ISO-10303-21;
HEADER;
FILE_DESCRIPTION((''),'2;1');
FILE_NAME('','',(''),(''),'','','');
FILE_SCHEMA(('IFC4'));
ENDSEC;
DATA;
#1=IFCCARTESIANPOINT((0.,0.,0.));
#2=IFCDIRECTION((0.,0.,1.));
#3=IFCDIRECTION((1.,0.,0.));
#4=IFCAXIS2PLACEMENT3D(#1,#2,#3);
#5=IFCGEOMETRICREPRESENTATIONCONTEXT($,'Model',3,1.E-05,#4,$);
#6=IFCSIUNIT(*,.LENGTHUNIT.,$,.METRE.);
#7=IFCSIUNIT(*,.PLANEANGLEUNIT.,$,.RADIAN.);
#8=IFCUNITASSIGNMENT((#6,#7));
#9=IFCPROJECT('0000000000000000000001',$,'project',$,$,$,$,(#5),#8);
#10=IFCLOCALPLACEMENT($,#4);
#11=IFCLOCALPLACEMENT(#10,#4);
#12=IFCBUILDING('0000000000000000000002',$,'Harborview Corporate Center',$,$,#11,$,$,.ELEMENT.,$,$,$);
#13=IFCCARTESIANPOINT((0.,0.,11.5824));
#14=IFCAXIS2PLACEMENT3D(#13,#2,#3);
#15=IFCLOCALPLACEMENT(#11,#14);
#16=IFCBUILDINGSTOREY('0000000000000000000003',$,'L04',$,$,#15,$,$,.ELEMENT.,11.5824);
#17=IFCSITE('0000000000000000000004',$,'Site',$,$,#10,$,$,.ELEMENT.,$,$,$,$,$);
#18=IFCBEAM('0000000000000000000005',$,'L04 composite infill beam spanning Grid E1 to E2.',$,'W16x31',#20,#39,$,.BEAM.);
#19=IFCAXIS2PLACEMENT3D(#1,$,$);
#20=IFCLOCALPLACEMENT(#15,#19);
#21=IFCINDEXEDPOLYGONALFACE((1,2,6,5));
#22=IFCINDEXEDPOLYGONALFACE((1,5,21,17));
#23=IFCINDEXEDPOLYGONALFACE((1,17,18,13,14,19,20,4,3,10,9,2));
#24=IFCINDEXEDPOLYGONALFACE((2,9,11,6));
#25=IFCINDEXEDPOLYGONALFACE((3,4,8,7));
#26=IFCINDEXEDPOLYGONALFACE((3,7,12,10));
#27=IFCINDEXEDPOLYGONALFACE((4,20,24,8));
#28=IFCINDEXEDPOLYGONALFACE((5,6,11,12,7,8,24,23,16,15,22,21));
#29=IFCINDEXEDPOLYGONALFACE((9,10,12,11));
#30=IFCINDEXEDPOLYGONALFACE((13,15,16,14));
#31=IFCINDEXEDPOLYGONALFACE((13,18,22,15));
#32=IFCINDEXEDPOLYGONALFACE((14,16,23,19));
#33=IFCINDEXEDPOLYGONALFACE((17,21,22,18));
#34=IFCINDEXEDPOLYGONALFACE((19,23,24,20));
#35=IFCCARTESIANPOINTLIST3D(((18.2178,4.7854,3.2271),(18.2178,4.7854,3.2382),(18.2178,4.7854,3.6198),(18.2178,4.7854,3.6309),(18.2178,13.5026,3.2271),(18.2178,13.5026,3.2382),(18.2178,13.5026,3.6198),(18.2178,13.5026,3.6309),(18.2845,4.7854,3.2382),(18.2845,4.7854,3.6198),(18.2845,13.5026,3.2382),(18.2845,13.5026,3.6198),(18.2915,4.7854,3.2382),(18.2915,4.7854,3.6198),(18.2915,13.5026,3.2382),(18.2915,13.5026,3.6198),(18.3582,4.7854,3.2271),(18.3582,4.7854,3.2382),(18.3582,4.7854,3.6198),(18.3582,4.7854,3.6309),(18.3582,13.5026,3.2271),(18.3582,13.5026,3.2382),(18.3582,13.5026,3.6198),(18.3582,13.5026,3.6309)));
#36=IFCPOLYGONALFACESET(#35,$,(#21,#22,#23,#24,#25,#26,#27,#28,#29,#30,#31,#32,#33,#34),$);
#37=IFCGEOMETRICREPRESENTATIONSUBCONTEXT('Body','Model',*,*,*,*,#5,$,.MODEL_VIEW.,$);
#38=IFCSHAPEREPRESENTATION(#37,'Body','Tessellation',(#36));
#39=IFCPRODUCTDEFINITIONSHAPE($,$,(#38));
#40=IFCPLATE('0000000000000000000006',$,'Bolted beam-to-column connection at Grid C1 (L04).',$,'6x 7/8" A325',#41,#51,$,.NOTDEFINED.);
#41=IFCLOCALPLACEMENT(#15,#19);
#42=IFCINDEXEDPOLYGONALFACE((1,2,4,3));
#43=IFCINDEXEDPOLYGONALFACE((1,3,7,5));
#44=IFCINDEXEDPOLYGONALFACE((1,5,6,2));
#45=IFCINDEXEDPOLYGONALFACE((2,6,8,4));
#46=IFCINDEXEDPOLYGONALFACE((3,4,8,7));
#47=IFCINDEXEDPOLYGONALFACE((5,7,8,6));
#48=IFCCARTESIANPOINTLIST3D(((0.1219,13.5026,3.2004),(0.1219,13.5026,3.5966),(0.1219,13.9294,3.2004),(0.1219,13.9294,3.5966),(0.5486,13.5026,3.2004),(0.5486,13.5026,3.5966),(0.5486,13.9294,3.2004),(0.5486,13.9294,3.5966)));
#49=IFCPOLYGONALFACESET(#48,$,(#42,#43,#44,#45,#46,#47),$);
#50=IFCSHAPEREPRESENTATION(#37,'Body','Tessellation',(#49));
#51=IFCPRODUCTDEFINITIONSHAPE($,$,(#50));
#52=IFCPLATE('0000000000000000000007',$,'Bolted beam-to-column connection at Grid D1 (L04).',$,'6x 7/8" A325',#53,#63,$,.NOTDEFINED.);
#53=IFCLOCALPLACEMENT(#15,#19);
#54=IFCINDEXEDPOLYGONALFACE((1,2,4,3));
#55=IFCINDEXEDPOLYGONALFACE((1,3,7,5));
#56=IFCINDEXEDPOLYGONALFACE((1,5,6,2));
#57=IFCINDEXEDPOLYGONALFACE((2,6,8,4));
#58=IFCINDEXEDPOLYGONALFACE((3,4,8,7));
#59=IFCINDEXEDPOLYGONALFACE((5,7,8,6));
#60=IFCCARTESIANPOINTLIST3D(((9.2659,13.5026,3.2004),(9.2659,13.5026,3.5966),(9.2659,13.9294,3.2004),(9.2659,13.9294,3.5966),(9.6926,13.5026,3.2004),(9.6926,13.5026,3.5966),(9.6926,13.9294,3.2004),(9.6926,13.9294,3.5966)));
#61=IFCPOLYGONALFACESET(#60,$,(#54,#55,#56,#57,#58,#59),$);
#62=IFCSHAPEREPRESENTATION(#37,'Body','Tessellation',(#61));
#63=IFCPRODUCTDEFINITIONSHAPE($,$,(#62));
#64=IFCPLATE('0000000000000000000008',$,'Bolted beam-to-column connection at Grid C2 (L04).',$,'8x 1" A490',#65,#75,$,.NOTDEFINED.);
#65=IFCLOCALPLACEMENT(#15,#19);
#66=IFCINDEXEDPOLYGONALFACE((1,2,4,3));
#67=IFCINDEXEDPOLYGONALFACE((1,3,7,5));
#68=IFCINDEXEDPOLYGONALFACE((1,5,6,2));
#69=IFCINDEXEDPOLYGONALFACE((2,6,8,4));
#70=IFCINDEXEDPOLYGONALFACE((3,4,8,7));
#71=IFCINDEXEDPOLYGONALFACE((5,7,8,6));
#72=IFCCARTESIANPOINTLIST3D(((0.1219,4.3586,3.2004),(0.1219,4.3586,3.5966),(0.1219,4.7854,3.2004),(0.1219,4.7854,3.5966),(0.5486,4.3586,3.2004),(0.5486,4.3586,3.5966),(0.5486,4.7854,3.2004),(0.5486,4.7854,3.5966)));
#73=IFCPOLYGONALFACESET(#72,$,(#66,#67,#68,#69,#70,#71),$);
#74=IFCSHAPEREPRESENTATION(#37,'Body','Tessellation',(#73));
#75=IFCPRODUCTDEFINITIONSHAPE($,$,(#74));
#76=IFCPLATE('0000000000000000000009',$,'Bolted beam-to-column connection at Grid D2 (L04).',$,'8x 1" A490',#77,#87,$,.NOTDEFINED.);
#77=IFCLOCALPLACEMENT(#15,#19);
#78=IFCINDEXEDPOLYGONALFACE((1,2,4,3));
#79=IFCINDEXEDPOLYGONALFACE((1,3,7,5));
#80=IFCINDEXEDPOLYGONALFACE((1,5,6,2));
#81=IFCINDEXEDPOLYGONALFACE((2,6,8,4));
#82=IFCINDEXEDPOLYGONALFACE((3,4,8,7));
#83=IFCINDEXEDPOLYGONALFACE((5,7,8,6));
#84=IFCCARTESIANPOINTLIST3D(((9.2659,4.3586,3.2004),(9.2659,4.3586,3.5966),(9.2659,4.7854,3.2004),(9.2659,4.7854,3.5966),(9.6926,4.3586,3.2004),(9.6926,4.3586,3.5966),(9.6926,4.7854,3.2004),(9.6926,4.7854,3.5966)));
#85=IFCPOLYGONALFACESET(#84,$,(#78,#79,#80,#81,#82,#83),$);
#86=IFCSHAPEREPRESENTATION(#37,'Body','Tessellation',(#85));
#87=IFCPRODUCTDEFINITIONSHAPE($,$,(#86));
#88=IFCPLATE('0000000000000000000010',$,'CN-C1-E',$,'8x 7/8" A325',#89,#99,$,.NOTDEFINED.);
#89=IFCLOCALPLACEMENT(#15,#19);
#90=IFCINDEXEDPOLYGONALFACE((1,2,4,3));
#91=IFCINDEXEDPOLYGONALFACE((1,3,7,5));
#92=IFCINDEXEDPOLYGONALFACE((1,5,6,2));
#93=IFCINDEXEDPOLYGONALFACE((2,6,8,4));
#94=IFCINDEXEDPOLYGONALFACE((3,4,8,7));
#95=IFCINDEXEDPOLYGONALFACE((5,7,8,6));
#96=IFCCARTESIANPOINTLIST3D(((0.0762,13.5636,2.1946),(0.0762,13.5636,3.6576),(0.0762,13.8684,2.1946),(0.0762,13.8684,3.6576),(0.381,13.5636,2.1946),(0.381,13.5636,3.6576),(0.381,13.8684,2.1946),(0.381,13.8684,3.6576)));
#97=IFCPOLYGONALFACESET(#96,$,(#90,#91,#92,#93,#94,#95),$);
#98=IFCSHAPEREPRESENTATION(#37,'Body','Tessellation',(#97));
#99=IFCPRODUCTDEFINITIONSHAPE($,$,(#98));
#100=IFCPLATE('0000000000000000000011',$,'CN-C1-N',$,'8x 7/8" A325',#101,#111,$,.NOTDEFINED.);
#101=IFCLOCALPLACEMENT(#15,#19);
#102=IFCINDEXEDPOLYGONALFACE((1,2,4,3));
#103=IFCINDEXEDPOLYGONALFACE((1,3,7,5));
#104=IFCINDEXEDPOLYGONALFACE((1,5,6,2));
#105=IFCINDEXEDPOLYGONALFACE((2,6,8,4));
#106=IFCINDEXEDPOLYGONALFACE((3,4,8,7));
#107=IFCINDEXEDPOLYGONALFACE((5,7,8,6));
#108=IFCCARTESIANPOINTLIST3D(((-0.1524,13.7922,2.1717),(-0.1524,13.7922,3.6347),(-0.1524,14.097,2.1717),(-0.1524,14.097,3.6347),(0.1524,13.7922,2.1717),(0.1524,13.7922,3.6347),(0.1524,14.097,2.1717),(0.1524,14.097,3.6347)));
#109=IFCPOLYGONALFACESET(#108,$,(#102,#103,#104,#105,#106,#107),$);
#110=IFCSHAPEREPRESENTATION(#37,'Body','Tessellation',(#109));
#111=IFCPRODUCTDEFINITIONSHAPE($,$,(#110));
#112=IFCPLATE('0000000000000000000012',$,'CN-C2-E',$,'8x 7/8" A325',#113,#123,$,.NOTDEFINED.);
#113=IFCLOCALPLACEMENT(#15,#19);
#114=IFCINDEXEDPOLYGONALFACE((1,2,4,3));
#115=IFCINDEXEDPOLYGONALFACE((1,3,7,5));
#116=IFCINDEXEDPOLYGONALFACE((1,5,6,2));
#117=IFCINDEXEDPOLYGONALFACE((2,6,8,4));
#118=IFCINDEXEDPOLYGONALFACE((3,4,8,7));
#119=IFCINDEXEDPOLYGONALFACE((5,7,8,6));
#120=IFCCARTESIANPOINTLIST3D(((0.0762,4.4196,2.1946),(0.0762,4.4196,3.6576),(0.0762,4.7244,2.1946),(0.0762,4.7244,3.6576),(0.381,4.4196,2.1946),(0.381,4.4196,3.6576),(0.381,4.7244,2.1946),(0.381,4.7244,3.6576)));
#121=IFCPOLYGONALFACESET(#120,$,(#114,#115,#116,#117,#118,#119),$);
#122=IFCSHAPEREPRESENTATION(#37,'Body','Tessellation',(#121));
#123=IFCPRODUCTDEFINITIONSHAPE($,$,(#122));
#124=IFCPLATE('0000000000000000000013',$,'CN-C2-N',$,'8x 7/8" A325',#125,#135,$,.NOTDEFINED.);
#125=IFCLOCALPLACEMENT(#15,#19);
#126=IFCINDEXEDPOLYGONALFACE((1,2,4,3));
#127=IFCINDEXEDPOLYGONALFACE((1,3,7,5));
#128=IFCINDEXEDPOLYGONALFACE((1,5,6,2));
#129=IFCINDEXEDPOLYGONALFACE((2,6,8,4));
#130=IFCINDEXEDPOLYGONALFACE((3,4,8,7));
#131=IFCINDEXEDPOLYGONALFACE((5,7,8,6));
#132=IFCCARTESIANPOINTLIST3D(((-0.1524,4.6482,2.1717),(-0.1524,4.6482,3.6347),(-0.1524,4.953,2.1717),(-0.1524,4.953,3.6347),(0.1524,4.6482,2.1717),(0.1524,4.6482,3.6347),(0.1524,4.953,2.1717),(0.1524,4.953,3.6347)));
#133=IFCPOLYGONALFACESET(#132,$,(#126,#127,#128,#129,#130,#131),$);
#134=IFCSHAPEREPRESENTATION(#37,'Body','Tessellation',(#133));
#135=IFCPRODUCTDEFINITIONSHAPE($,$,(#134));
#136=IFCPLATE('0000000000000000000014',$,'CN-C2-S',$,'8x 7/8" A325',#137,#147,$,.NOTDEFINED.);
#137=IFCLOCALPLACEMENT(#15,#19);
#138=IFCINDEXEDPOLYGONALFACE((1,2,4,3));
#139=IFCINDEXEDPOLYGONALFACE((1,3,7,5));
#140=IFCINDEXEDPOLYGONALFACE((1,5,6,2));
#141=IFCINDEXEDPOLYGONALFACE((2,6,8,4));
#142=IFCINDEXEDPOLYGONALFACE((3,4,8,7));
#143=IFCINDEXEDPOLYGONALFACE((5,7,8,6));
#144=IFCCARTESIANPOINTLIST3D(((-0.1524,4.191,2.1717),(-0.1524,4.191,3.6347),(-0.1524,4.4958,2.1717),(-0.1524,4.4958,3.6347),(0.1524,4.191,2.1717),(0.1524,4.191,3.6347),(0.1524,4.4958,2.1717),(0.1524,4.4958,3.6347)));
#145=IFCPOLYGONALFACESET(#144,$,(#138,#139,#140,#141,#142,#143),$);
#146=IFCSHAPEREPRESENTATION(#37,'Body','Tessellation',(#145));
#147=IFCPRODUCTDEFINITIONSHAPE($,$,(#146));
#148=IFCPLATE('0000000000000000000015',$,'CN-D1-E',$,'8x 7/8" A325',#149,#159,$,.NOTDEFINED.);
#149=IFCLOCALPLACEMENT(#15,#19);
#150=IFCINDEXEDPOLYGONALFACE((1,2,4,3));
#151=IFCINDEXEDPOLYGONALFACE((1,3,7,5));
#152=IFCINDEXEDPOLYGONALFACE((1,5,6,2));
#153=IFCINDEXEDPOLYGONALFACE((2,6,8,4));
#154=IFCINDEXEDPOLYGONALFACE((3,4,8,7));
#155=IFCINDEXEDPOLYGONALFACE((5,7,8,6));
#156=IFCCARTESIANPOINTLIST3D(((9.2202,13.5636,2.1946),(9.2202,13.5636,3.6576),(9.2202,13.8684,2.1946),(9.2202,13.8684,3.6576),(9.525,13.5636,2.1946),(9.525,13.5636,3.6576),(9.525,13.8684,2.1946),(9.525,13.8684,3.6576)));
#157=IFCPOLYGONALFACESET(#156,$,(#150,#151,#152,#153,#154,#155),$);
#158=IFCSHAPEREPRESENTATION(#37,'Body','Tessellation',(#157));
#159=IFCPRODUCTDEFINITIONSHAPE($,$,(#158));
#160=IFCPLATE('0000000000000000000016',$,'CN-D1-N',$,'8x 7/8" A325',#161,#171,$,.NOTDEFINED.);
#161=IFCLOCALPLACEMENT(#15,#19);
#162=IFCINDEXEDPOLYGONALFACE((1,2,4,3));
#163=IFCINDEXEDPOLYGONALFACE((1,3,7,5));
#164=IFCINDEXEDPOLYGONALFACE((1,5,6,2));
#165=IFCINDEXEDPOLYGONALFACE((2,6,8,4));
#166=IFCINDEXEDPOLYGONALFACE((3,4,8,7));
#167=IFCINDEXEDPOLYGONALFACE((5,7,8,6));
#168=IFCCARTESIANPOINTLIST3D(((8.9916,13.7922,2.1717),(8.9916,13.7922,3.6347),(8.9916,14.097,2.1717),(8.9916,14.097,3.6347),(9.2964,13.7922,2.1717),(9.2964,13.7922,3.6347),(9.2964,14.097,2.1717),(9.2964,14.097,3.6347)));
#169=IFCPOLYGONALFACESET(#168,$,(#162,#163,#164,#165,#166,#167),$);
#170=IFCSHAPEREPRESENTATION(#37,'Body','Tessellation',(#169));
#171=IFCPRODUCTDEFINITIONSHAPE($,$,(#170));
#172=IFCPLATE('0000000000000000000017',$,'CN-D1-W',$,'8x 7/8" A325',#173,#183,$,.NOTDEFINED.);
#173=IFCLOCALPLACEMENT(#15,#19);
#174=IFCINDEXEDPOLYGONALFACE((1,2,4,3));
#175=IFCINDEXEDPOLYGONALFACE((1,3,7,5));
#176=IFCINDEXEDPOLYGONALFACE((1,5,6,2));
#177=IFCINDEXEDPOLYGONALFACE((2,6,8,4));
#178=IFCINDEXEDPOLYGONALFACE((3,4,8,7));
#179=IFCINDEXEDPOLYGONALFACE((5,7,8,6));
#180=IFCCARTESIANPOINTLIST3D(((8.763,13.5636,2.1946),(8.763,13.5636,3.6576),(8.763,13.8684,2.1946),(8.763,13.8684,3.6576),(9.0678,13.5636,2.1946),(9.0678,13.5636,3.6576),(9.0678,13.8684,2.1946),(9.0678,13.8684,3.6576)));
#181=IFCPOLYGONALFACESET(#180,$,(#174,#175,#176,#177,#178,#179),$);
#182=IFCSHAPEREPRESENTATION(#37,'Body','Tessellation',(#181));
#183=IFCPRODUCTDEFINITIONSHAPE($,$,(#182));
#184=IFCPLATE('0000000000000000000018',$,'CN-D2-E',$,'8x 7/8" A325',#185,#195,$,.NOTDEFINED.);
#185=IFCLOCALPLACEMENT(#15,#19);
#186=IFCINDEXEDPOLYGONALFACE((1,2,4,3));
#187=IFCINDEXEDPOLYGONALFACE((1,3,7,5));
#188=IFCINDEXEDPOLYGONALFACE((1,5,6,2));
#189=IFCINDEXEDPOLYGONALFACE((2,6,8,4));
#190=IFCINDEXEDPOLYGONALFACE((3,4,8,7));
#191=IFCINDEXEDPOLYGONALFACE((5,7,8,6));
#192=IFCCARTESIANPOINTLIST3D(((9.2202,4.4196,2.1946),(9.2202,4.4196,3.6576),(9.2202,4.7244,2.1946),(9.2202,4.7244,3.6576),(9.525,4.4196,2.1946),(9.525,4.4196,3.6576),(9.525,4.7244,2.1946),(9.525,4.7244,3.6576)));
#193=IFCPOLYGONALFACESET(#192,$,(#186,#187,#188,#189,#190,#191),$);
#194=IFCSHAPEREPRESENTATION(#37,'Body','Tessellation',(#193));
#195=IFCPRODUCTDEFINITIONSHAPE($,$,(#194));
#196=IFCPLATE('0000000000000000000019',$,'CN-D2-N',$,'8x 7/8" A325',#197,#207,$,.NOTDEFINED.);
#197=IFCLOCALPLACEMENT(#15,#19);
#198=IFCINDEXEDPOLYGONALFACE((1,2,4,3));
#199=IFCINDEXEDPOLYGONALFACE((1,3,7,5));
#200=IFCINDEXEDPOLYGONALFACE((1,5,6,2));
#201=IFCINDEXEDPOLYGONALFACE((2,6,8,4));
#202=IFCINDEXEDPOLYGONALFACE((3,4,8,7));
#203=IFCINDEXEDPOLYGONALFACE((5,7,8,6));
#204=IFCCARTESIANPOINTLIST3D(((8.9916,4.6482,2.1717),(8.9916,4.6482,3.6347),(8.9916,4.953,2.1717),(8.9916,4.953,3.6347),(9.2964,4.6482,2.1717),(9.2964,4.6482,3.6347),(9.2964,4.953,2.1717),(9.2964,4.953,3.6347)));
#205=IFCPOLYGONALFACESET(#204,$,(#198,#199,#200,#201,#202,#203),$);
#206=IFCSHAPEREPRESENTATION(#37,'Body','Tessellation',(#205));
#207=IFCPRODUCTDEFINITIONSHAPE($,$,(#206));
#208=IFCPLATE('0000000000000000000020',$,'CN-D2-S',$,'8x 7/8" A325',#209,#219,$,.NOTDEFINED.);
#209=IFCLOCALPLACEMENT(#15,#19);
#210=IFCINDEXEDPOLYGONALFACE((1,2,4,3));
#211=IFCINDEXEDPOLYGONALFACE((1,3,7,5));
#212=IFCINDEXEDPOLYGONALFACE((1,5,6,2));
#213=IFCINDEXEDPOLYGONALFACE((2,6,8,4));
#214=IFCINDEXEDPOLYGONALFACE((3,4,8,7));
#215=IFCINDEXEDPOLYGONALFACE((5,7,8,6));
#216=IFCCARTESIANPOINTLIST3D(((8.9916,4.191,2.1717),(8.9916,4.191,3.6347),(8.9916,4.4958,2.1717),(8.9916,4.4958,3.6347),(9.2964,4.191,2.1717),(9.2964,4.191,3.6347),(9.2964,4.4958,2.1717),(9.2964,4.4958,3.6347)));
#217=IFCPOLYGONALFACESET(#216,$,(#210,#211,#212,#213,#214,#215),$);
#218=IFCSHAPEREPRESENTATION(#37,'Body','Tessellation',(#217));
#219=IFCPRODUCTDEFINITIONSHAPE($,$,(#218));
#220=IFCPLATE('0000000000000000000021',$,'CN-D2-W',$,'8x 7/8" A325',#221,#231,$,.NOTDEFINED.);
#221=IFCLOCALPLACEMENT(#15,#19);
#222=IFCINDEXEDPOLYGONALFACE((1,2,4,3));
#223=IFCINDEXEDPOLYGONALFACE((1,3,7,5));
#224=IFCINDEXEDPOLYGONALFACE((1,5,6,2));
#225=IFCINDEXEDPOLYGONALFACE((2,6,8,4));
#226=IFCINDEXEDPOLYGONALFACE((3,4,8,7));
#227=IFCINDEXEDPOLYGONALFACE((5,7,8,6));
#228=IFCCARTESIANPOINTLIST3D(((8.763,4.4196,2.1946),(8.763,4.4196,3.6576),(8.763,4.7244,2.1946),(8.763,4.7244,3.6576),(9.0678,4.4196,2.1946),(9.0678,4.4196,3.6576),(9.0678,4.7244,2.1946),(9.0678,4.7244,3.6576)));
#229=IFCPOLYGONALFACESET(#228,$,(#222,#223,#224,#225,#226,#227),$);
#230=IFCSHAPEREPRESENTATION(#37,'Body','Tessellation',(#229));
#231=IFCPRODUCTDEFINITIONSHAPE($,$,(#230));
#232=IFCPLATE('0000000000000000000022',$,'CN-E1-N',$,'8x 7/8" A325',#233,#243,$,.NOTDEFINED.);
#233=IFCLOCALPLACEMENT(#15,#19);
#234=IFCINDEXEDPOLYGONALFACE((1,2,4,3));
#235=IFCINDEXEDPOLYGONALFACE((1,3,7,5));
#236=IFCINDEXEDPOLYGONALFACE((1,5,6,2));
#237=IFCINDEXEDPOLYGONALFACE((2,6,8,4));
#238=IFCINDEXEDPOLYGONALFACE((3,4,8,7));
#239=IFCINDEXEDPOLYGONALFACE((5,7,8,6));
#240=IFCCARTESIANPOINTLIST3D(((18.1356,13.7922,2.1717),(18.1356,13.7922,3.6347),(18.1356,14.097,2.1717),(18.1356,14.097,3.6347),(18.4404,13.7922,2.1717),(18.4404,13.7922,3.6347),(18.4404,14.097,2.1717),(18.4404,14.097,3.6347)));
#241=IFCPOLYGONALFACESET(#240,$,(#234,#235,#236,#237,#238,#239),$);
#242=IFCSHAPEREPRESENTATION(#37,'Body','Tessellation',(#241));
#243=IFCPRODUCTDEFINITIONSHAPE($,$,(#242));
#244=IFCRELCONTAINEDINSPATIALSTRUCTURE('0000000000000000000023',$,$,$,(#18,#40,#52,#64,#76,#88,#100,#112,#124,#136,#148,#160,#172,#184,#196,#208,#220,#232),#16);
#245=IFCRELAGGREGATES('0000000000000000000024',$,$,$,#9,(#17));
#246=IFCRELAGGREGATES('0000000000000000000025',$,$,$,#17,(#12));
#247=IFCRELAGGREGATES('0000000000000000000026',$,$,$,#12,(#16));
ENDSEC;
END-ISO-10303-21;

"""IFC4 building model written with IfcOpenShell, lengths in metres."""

from ifc_helpers import new_model, si_unit, frame, origin_with_axes, place, context, subcontext, project, spatial, rectangle, i_section, extrude, element, save


model = new_model("IFC4")

# Units and contexts
model_context = context("Model", 3, precision=1e-05, world=origin_with_axes())
body_context = subcontext(model_context, "Body", "Model", "MODEL_VIEW")
ifc_project = project(units=[si_unit("LENGTHUNIT", "METRE"), si_unit("PLANEANGLEUNIT", "RADIAN")], contexts=[model_context])

# Site, building, storey
site_placement = place(None, origin_with_axes())
site = spatial("IfcSite", under=ifc_project, at=site_placement, Name="Site", CompositionType="ELEMENT")
building_placement = place(site_placement, origin_with_axes())
building = spatial("IfcBuilding", under=site, at=building_placement, Name="Harborview Corporate Center", CompositionType="ELEMENT")
storey_placement = place(building_placement, frame((0.0, 0.0, 11.5824), z_axis=(0.0, 0.0, 1.0), x_axis=(1.0, 0.0, 0.0)))
storey = spatial("IfcBuildingStorey", under=building, at=storey_placement, Name="L04", CompositionType="ELEMENT", Elevation=11.5824)

# Beam
for number, where, z_axis, x_axis, name in (
    (1, (18.288, 4.7854, 3.429), (0.0, 1.0, 0.0), (-1.0, 0.0, 0.0), "L04 composite infill beam spanning Grid E1 to E2."),
):
    element("IfcBeam", number, at=place(storey_placement, frame(where, z_axis=z_axis, x_axis=x_axis)), inside=storey, Name=name, ObjectType="W16x31", PredefinedType="BEAM", context=body_context, shape_type="SweptSolid", body=[
        extrude(i_section(OverallWidth=0.1405, OverallDepth=0.4039, WebThickness=0.007, FlangeThickness=0.0112), origin_with_axes(), (0.0, 0.0, 1.0), 8.7173),
    ])

# Plates
plate_1_placement = place(storey_placement, frame((0.3353, 13.716, 3.2004), z_axis=(0.0, 0.0, 1.0), x_axis=(1.0, 0.0, 0.0)))
element("IfcPlate", 2, at=plate_1_placement, inside=storey, Name="Bolted beam-to-column connection at Grid C1 (L04).", ObjectType="6x 7/8\" A325", PredefinedType="NOTDEFINED", context=body_context, shape_type="SweptSolid", body=[
    extrude(rectangle(XDim=0.4267, YDim=0.4267), origin_with_axes(), (0.0, 0.0, 1.0), 0.3962),
])
plate_2_placement = place(storey_placement, frame((9.4793, 13.716, 3.2004), z_axis=(0.0, 0.0, 1.0), x_axis=(1.0, 0.0, 0.0)))
element("IfcPlate", 3, at=plate_2_placement, inside=storey, Name="Bolted beam-to-column connection at Grid D1 (L04).", ObjectType="6x 7/8\" A325", PredefinedType="NOTDEFINED", context=body_context, shape_type="SweptSolid", body=[
    extrude(rectangle(XDim=0.4267, YDim=0.4267), origin_with_axes(), (0.0, 0.0, 1.0), 0.3962),
])
plate_3_placement = place(storey_placement, frame((0.3353, 4.572, 3.2004), z_axis=(0.0, 0.0, 1.0), x_axis=(1.0, 0.0, 0.0)))
element("IfcPlate", 4, at=plate_3_placement, inside=storey, Name="Bolted beam-to-column connection at Grid C2 (L04).", ObjectType="8x 1\" A490", PredefinedType="NOTDEFINED", context=body_context, shape_type="SweptSolid", body=[
    extrude(rectangle(XDim=0.4267, YDim=0.4267), origin_with_axes(), (0.0, 0.0, 1.0), 0.3962),
])
plate_4_placement = place(storey_placement, frame((9.4793, 4.572, 3.2004), z_axis=(0.0, 0.0, 1.0), x_axis=(1.0, 0.0, 0.0)))
element("IfcPlate", 5, at=plate_4_placement, inside=storey, Name="Bolted beam-to-column connection at Grid D2 (L04).", ObjectType="8x 1\" A490", PredefinedType="NOTDEFINED", context=body_context, shape_type="SweptSolid", body=[
    extrude(rectangle(XDim=0.4267, YDim=0.4267), origin_with_axes(), (0.0, 0.0, 1.0), 0.3962),
])
for number, where, z_axis, x_axis, name in (
    (6, (0.2286, 13.716, 2.1946), (0.0, 0.0, 1.0), (1.0, 0.0, 0.0), "CN-C1-E"),
    (7, (0.0, 13.9446, 2.1717), (0.0, 0.0, 1.0), (1.0, 0.0, 0.0), "CN-C1-N"),
    (8, (0.2286, 4.572, 2.1946), (0.0, 0.0, 1.0), (1.0, 0.0, 0.0), "CN-C2-E"),
    (9, (0.0, 4.8006, 2.1717), (0.0, 0.0, 1.0), (1.0, 0.0, 0.0), "CN-C2-N"),
    (10, (0.0, 4.3434, 2.1717), (0.0, 0.0, 1.0), (1.0, 0.0, 0.0), "CN-C2-S"),
):
    element("IfcPlate", number, at=place(storey_placement, frame(where, z_axis=z_axis, x_axis=x_axis)), inside=storey, Name=name, ObjectType="8x 7/8\" A325", PredefinedType="NOTDEFINED", context=body_context, shape_type="SweptSolid", body=[
        extrude(rectangle(XDim=0.3048, YDim=0.3048), origin_with_axes(), (0.0, 0.0, 1.0), 1.463),
    ])
for number, where, z_axis, x_axis, name in (
    (11, (9.3726, 13.716, 2.1946), (0.0, 0.0, 1.0), (1.0, 0.0, 0.0), "CN-D1-E"),
    (12, (9.144, 13.9446, 2.1717), (0.0, 0.0, 1.0), (1.0, 0.0, 0.0), "CN-D1-N"),
    (13, (8.9154, 13.716, 2.1946), (0.0, 0.0, 1.0), (1.0, 0.0, 0.0), "CN-D1-W"),
    (14, (9.3726, 4.572, 2.1946), (0.0, 0.0, 1.0), (1.0, 0.0, 0.0), "CN-D2-E"),
    (15, (9.144, 4.8006, 2.1717), (0.0, 0.0, 1.0), (1.0, 0.0, 0.0), "CN-D2-N"),
    (16, (9.144, 4.3434, 2.1717), (0.0, 0.0, 1.0), (1.0, 0.0, 0.0), "CN-D2-S"),
    (17, (8.9154, 4.572, 2.1946), (0.0, 0.0, 1.0), (1.0, 0.0, 0.0), "CN-D2-W"),
    (18, (18.288, 13.9446, 2.1717), (0.0, 0.0, 1.0), (1.0, 0.0, 0.0), "CN-E1-N"),
):
    element("IfcPlate", number, at=place(storey_placement, frame(where, z_axis=z_axis, x_axis=x_axis)), inside=storey, Name=name, ObjectType="8x 7/8\" A325", PredefinedType="NOTDEFINED", context=body_context, shape_type="SweptSolid", body=[
        extrude(rectangle(XDim=0.3048, YDim=0.3048), origin_with_axes(), (0.0, 0.0, 1.0), 1.463),
    ])

save(model, "model.ifc")
